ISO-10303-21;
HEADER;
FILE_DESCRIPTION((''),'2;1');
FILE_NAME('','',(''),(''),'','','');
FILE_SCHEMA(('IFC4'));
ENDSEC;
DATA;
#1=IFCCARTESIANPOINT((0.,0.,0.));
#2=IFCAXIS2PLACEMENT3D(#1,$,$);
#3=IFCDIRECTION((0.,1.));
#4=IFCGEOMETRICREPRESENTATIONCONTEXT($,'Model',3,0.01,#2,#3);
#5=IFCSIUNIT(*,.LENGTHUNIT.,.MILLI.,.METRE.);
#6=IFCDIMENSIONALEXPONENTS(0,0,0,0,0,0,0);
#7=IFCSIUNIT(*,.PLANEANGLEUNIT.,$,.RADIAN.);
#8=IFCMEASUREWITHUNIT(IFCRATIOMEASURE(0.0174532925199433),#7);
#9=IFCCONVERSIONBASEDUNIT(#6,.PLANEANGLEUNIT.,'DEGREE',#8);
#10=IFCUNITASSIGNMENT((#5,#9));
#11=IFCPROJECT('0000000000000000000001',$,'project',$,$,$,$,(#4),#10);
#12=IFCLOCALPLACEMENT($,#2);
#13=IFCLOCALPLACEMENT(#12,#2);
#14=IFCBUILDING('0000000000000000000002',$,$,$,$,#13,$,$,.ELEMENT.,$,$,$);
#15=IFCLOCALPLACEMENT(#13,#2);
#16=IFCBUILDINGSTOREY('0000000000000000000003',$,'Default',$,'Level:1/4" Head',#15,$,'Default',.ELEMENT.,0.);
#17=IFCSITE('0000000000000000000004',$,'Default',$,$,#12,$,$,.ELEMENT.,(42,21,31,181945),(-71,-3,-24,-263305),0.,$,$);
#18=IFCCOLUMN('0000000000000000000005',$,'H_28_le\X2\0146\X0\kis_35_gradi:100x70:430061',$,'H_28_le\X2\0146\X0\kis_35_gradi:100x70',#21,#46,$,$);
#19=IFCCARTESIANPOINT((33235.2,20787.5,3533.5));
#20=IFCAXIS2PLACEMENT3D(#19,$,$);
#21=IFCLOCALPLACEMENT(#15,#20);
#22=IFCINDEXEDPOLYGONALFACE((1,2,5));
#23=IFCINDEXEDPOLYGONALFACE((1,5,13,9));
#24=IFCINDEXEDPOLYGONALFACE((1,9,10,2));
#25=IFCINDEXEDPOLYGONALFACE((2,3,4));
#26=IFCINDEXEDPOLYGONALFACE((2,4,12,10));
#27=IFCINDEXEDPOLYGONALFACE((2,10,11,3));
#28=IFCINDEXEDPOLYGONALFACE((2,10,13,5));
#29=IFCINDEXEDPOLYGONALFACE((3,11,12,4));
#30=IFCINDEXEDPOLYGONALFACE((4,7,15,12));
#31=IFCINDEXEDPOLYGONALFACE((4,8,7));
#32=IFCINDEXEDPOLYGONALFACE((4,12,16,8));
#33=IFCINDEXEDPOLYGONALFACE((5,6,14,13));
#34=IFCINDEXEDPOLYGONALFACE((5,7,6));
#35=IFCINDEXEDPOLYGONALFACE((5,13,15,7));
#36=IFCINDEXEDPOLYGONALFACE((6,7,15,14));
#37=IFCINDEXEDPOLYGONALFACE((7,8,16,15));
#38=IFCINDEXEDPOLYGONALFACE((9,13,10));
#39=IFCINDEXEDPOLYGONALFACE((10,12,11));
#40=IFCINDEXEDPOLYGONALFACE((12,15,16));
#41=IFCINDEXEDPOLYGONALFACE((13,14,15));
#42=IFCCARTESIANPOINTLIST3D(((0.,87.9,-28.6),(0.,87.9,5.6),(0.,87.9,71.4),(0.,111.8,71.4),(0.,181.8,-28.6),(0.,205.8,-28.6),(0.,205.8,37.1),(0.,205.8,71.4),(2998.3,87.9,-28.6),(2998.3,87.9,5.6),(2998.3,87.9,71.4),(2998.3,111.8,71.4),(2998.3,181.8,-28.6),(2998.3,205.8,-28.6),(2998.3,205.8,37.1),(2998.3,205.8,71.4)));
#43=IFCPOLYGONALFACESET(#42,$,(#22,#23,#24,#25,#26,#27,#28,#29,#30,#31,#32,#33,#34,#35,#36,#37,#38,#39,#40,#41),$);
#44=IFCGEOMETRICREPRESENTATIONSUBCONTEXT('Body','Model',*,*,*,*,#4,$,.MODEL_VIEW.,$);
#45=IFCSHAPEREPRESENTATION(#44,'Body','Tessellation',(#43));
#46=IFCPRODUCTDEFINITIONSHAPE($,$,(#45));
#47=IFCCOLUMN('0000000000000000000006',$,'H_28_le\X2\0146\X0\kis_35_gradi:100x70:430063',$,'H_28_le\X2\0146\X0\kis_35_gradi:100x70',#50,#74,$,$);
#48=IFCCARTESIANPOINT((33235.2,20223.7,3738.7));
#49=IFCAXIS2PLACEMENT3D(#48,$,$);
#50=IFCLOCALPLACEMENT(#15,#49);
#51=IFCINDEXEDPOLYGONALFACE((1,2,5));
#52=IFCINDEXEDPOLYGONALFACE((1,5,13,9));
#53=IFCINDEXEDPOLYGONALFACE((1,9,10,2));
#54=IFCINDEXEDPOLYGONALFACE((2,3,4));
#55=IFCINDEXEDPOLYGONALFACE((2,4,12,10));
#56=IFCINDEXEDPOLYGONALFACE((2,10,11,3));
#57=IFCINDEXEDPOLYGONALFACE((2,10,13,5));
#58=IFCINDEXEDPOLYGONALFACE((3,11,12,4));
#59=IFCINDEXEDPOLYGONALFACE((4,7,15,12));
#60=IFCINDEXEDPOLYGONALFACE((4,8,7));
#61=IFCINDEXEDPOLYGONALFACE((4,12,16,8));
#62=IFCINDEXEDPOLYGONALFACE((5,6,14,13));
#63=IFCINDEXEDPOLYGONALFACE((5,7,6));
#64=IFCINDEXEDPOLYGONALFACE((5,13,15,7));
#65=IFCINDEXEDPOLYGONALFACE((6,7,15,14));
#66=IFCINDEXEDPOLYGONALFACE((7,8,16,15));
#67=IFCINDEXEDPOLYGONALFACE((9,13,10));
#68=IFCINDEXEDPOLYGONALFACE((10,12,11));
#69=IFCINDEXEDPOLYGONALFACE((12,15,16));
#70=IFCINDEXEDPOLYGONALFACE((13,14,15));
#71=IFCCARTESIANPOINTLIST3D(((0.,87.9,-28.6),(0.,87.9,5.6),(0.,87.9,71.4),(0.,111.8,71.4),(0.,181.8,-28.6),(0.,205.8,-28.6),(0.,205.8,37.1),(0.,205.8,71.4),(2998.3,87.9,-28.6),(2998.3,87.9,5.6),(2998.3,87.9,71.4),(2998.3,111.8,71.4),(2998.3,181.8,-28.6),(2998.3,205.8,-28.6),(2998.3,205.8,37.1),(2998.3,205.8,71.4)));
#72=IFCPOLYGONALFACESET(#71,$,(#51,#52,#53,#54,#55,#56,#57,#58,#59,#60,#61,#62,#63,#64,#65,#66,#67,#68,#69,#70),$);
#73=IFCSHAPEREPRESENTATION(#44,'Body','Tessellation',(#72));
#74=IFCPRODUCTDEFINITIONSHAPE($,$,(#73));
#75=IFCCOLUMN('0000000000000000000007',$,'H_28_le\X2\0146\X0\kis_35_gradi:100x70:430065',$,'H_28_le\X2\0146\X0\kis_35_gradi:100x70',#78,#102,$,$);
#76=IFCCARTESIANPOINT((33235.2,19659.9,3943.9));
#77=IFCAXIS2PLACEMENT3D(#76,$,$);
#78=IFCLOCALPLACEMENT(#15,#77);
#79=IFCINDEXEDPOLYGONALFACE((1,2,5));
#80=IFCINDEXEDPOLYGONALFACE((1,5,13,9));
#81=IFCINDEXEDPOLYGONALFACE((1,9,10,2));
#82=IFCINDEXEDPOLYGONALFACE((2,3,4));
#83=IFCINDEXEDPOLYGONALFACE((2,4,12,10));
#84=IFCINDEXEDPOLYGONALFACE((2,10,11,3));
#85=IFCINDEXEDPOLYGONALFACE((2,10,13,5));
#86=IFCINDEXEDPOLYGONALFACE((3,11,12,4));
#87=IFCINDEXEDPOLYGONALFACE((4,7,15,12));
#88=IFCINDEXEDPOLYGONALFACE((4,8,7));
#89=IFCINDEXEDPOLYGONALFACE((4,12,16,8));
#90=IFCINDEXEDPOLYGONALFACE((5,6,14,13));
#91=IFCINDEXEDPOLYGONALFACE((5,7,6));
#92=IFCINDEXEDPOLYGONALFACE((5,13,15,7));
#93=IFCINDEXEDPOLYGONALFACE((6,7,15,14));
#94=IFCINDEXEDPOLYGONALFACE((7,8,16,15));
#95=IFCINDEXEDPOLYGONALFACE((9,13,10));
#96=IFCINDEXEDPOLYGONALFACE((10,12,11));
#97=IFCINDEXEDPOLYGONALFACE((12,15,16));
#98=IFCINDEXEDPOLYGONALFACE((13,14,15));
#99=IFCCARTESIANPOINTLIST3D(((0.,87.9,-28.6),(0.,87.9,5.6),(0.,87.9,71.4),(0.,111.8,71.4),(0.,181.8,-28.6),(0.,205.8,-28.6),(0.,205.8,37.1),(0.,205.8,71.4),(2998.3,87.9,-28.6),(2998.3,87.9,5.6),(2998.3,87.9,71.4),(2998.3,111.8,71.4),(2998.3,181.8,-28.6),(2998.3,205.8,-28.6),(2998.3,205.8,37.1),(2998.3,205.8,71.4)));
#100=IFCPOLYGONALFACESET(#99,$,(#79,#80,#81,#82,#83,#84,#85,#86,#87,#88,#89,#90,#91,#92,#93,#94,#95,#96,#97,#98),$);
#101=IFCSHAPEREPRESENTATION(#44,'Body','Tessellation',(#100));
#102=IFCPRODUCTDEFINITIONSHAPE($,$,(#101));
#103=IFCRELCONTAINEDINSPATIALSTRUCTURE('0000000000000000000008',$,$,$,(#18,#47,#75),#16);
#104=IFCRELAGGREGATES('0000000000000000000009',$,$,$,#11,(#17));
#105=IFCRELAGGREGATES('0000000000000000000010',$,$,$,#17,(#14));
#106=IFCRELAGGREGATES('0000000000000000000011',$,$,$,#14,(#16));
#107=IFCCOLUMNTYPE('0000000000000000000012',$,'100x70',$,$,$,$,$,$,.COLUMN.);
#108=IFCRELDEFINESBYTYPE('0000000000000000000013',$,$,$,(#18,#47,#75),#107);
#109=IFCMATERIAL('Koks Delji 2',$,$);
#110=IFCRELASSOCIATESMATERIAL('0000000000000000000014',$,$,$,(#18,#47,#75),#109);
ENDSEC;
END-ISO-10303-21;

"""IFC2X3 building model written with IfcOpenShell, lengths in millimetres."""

from ifc_helpers import new_model, entity, si_unit, converted_unit, direction, frame, frame_2d, origin, place, context, subcontext, project, spatial, rectangle, extrude, boolean, source, transform, mapped, material, type_object, type_shapes, element, save


model = new_model("IFC2X3")

# Units and contexts
model_context = context("Model", 3, precision=0.01, world=origin(), true_north=direction((0.0, 1.0)))
body_context = subcontext(model_context, "Body", "Model", "MODEL_VIEW")
ifc_project = project(units=[si_unit("LENGTHUNIT", "METRE", prefix="MILLI"), converted_unit("PLANEANGLEUNIT", "DEGREE", entity("IfcRatioMeasure", 0.0174532925199433), si_unit("PLANEANGLEUNIT", "RADIAN"), dimensions=[0, 0, 0, 0, 0, 0, 0])], contexts=[model_context])

# Site, building, storey
site_placement = place(None, origin())
site = spatial("IfcSite", under=ifc_project, at=site_placement, Name="Default", CompositionType="ELEMENT", RefLatitude=(42, 21, 31, 181945), RefLongitude=(-71, -3, -24, -263305), RefElevation=0.0)
building_placement = place(site_placement, origin())
building = spatial("IfcBuilding", under=site, at=building_placement, CompositionType="ELEMENT")
storey_placement = place(building_placement, origin())
storey = spatial("IfcBuildingStorey", under=building, at=storey_placement, Name="Default", ObjectType="Level:1/4\" Head", LongName="Default", CompositionType="ELEMENT", Elevation=0.0)

# Columns
ifc_material_1 = material(Name="Koks Delji 2")
column_type_1 = type_object("IfcColumnType", Name="100x70", PredefinedType="COLUMN")
shared_shape_1 = source(origin(), body_context, "Body", "CSG", [
    boolean("DIFFERENCE", extrude(rectangle(XDim=2998.3, YDim=117.9, at=frame_2d((0.0, 0.0), x_axis=(1.0, 0.0))), frame((1499.1, 146.8, -28.6)), (0.0, 0.0, 1.0), 100.0), extrude(rectangle(XDim=70.0, YDim=100.0, at=frame_2d((0.0, 0.0), x_axis=(0.0, 1.0))), frame((2998.3, 146.8, 21.4), z_axis=(1.0, 0.0, 0.0), x_axis=(0.0, 0.939693, -0.34202)), (0.0, 0.0, -1.0), 2998.3)),
])
type_shapes(column_type_1, [shared_shape_1])
for number, where, name in (
    (1, (33235.2, 20787.5, 3533.5), "H_28_leņkis_35_gradi:100x70:430061"),
    (2, (33235.2, 20223.7, 3738.7), "H_28_leņkis_35_gradi:100x70:430063"),
    (3, (33235.2, 19659.9, 3943.9), "H_28_leņkis_35_gradi:100x70:430065"),
):
    element("IfcColumn", number, at=place(storey_placement, frame(where)), inside=storey, type_object=column_type_1, material=ifc_material_1, Name=name, ObjectType="H_28_leņkis_35_gradi:100x70", context=body_context, shape_type="MappedRepresentation", body=[
        mapped(shared_shape_1, transform((0.0, 0.0, 0.0), scale=1.0)),
    ])

save(model, "model.ifc")
